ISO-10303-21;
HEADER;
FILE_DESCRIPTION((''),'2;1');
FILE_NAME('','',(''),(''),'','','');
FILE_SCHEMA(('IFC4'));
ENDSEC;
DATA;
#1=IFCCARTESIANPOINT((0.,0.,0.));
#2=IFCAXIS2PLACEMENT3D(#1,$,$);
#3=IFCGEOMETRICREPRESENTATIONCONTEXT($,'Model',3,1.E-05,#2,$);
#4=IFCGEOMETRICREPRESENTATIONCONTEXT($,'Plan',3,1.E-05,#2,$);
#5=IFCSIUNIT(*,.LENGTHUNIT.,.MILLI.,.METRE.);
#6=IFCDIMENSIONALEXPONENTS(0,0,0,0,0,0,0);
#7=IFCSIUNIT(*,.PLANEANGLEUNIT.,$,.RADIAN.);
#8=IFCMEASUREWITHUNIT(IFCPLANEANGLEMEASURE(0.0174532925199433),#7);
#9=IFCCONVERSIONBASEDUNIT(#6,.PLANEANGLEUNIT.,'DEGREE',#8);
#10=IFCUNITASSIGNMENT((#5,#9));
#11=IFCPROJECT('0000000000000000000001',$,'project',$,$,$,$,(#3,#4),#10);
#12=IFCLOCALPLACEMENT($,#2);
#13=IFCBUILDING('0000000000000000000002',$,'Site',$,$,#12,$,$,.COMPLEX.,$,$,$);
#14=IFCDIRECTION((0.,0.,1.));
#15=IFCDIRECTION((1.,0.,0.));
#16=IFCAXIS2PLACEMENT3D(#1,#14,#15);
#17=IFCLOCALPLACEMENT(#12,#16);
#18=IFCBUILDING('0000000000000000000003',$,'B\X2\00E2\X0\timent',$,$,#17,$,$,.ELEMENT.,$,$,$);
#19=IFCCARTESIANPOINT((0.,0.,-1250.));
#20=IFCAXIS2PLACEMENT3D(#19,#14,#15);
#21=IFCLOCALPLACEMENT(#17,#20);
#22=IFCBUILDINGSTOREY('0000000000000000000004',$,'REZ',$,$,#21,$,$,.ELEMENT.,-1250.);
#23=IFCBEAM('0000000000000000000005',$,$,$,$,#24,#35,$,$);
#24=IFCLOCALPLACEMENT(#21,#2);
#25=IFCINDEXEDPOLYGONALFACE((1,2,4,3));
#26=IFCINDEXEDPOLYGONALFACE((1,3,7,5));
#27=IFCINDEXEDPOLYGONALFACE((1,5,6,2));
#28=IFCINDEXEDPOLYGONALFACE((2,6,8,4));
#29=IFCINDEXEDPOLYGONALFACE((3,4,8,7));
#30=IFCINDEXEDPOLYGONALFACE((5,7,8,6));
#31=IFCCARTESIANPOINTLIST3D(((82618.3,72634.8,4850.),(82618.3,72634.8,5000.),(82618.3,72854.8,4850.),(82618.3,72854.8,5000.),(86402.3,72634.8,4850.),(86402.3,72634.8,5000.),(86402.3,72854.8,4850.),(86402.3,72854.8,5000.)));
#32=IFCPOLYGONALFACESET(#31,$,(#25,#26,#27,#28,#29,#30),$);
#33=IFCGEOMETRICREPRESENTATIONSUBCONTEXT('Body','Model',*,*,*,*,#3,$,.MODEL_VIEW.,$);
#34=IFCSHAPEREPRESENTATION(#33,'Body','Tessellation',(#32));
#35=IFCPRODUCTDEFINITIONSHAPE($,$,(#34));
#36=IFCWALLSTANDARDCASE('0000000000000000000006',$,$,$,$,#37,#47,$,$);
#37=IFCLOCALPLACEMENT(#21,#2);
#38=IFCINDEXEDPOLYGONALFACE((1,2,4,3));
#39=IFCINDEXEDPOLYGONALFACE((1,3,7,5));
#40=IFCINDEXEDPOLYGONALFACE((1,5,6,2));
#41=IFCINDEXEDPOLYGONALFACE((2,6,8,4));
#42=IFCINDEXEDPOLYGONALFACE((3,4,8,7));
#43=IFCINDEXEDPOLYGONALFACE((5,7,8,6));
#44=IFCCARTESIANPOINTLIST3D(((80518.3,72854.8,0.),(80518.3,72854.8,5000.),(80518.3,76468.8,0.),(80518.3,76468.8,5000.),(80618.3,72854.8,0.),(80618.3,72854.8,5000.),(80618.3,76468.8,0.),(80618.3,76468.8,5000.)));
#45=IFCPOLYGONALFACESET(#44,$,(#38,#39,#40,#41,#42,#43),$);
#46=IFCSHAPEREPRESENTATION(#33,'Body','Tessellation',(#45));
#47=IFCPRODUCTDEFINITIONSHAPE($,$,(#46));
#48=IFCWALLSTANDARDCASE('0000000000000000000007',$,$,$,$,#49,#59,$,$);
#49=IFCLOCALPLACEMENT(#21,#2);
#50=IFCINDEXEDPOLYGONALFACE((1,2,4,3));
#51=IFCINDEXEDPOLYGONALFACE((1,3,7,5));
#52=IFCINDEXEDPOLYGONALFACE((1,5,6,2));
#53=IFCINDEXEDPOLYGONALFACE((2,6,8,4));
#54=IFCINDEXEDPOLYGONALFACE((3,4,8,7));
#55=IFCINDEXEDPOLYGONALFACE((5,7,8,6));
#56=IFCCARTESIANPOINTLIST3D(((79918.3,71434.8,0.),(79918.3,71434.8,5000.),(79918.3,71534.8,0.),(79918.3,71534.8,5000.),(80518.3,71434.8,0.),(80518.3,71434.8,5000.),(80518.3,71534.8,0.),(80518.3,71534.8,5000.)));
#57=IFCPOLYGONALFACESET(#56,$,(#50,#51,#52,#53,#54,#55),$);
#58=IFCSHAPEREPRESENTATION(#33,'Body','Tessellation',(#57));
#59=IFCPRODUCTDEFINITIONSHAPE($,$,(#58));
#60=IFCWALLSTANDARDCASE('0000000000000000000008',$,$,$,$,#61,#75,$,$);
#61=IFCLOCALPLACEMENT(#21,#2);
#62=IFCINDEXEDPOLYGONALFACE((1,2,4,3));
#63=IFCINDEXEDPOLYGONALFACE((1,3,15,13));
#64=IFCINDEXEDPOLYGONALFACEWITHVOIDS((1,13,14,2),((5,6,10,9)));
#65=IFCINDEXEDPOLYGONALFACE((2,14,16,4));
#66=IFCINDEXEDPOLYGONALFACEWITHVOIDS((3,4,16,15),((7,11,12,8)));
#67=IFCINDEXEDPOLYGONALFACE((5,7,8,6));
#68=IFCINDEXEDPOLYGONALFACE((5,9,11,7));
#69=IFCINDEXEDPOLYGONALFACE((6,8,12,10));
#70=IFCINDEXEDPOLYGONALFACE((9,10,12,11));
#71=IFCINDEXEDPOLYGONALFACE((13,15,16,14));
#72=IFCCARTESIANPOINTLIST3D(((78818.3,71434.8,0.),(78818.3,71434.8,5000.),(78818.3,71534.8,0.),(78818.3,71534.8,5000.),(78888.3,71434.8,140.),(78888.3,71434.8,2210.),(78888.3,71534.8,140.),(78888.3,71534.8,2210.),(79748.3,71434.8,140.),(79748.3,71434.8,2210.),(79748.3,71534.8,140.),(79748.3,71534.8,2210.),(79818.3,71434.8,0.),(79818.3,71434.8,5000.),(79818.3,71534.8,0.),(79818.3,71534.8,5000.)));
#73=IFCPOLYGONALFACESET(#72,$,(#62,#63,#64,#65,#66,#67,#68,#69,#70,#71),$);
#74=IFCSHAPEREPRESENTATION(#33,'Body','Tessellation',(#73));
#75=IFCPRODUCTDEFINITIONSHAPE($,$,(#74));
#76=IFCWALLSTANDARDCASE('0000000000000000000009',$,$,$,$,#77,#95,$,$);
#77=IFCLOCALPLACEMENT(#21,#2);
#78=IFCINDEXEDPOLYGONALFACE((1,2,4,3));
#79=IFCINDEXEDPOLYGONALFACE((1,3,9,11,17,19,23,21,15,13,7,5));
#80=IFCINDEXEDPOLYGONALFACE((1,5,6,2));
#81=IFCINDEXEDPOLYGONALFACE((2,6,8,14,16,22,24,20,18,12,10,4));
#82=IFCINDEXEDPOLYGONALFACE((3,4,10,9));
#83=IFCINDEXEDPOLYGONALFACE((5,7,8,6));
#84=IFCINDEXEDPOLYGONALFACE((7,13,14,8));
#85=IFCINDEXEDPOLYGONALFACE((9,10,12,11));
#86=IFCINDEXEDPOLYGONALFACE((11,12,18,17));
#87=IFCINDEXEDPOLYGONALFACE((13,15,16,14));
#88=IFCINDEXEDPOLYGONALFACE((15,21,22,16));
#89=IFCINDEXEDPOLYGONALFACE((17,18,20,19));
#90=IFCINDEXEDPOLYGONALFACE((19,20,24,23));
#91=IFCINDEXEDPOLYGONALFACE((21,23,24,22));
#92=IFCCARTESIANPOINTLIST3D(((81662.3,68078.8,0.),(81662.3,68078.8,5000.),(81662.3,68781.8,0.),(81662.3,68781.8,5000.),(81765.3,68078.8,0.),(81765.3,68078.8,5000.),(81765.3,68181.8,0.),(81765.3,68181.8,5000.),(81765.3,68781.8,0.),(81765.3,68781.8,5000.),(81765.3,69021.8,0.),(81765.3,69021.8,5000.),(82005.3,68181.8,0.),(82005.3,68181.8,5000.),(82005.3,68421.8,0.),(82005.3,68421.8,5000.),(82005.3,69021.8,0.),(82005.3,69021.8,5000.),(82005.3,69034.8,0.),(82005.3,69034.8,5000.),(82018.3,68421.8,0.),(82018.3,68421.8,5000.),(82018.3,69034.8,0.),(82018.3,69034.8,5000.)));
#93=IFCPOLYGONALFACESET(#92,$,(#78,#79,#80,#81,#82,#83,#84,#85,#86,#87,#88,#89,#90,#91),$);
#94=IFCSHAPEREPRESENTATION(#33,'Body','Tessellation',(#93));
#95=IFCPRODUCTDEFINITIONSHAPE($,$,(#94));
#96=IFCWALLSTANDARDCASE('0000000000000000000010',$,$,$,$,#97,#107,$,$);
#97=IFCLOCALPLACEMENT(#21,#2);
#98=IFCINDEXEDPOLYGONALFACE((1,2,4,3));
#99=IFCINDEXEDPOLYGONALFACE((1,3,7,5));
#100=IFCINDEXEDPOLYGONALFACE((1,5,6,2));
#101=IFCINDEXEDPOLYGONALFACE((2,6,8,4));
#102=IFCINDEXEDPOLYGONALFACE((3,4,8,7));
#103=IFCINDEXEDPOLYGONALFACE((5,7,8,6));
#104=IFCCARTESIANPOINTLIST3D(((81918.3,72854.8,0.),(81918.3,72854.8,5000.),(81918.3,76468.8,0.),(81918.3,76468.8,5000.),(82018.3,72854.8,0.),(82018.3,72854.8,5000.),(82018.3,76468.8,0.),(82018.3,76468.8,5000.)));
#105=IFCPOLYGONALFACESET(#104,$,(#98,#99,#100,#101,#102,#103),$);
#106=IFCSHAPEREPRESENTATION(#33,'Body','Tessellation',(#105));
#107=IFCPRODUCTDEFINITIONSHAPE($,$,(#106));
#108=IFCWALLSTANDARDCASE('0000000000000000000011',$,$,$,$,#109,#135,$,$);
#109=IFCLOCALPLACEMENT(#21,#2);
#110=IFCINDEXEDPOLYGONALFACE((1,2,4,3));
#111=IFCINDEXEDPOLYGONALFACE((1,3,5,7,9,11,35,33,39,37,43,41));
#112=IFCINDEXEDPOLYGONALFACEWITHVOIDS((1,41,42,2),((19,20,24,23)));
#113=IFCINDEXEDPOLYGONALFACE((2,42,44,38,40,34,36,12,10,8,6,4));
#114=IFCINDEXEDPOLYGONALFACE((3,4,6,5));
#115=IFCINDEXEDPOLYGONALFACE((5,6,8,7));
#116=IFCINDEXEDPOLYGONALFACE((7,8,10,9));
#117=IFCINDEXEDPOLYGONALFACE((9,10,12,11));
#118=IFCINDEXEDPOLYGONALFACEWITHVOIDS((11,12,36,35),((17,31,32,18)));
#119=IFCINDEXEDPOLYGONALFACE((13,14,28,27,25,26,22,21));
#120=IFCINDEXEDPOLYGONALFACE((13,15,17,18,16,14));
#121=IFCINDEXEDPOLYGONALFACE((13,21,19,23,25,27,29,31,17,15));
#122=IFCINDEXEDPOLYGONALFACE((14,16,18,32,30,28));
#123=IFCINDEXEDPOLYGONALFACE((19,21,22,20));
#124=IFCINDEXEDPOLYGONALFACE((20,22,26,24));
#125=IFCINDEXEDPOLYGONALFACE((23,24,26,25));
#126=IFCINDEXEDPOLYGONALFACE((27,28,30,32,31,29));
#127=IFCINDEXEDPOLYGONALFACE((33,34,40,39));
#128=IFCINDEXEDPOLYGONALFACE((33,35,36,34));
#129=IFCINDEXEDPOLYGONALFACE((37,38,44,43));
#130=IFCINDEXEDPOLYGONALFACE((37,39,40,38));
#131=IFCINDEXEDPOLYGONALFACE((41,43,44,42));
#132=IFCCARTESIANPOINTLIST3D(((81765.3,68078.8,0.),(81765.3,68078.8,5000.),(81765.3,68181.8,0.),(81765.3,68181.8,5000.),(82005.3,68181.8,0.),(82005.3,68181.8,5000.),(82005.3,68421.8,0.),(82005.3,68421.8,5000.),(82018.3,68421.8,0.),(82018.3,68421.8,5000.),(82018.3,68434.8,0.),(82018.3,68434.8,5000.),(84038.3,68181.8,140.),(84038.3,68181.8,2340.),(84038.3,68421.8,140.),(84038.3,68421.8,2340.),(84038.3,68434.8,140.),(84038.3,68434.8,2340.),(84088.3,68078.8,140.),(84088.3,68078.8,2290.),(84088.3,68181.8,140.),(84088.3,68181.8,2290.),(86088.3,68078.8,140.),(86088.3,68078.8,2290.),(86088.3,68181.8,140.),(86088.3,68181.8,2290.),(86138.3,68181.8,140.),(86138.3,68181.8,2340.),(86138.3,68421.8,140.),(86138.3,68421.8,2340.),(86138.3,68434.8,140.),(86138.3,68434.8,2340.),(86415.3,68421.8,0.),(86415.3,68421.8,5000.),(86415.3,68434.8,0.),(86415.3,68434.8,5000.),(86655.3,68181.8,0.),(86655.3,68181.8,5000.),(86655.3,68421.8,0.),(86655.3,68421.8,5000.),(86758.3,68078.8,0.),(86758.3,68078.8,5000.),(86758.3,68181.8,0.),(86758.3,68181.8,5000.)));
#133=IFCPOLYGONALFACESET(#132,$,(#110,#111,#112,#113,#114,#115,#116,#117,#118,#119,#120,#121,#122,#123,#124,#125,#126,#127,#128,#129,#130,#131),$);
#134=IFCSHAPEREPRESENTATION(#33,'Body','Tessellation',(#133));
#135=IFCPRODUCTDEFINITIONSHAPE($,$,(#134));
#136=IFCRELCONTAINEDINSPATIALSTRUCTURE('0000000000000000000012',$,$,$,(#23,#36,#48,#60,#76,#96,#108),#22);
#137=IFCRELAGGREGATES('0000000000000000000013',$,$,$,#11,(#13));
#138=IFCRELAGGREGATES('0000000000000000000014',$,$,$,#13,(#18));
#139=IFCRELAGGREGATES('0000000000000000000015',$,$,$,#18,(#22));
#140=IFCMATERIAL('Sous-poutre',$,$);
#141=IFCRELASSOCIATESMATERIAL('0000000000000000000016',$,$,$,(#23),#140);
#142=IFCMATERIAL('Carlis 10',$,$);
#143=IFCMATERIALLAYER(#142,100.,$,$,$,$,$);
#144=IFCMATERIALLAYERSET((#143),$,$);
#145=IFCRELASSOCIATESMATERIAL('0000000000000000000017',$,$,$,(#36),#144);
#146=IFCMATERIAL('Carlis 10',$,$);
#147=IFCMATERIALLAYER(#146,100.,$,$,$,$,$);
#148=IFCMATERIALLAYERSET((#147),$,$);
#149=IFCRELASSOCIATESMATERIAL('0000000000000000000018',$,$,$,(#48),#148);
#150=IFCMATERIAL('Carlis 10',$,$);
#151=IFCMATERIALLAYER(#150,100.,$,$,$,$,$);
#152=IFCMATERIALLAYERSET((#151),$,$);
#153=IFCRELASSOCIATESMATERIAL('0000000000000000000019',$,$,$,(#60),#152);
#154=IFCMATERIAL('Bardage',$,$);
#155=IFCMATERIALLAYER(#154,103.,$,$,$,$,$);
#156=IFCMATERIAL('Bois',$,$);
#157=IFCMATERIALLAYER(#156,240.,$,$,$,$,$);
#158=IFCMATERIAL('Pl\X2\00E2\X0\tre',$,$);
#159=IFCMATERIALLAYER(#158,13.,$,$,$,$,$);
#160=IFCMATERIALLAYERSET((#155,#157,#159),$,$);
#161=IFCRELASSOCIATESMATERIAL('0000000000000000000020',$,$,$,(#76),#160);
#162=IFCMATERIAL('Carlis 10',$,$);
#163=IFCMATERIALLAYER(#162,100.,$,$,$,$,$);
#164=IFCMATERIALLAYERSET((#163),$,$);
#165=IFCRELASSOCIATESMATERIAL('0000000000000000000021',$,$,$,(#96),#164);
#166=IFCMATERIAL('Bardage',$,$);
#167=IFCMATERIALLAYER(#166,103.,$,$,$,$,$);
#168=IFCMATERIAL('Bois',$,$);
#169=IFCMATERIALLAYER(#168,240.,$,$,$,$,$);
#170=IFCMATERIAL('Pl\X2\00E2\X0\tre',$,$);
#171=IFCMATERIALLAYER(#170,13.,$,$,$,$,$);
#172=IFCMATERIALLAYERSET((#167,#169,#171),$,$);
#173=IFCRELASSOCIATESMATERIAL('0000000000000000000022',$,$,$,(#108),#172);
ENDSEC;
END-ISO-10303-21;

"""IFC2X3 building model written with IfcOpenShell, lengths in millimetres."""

from ifc_helpers import new_model, entity, si_unit, converted_unit, frame, frame_2d, origin, origin_with_axes, place, context, subcontext, project, spatial, polyline, rectangle, outline, extrude, material, layer, layer_set, layer_usage, element, save


model = new_model("IFC2X3")

# Units and contexts
model_context = context("Model", 3, precision=1e-05, world=origin())
plan_context = context("Plan", 3, precision=1e-05, world=origin())
body_context = subcontext(model_context, "Body", "Model", "MODEL_VIEW")
ifc_project = project(units=[si_unit("LENGTHUNIT", "METRE", prefix="MILLI"), converted_unit("PLANEANGLEUNIT", "DEGREE", entity("IfcPlaneAngleMeasure", 0.0174532925199433), si_unit("PLANEANGLEUNIT", "RADIAN"), dimensions=[0, 0, 0, 0, 0, 0, 0])], contexts=[model_context, plan_context])

# Buildings, storey
building_1_placement = place(None, origin())
building_1 = spatial("IfcBuilding", under=ifc_project, at=building_1_placement, Name="Site", CompositionType="COMPLEX")
building_2_placement = place(building_1_placement, origin_with_axes())
building_2 = spatial("IfcBuilding", under=building_1, at=building_2_placement, Name="Bâtiment", CompositionType="ELEMENT")
storey_placement = place(building_2_placement, frame((0.0, 0.0, -1250.0), z_axis=(0.0, 0.0, 1.0), x_axis=(1.0, 0.0, 0.0)))
storey = spatial("IfcBuildingStorey", under=building_2, at=storey_placement, Name="REZ", CompositionType="ELEMENT", Elevation=-1250.0)

# Beam
ifc_material_1 = material(Name="Sous-poutre")
beam_placement = place(storey_placement, frame((82618.3, 72634.8, 4850.0), z_axis=(0.0, 0.0, 1.0), x_axis=(1.0, 0.0, 0.0)))
element("IfcBeam", 1, at=beam_placement, inside=storey, material=ifc_material_1, context=body_context, shape_type="SweptSolid", body=[
    extrude(rectangle(XDim=150.0, YDim=220.0, at=frame_2d((75.0, -110.0), x_axis=(1.0, 0.0))), frame((0.0, 0.0, 0.0), z_axis=(1.0, 0.0, 0.0), x_axis=(0.0, 0.0, 1.0)), (0.0, 0.0, 1.0), 3784.0),
])

# Wall
ifc_material_2 = material(Name="Carlis 10")
ifc_layer_1 = layer(ifc_material_2, 100.0)
ifc_layer_set_1 = layer_set([ifc_layer_1])
ifc_layer_usage_1 = layer_usage(ifc_layer_set_1, "AXIS2", "POSITIVE", 0.0)
wall_1_placement = place(storey_placement, frame((80518.3, 76468.8, 0.0), z_axis=(0.0, 0.0, 1.0), x_axis=(0.0, -1.0, 0.0)))
element("IfcWallStandardCase", 2, at=wall_1_placement, inside=storey, material=ifc_layer_usage_1, context=body_context, shape_type="SweptSolid", body=[
    extrude(rectangle(XDim=3614.0, YDim=100.0, at=frame_2d((1807.0, 50.0), x_axis=(1.0, 0.0))), origin_with_axes(), (0.0, 0.0, 1.0), 5000.0),
])

# Wall
ifc_material_3 = material(Name="Carlis 10")
ifc_layer_2 = layer(ifc_material_3, 100.0)
ifc_layer_set_2 = layer_set([ifc_layer_2])
ifc_layer_usage_2 = layer_usage(ifc_layer_set_2, "AXIS2", "POSITIVE", 0.0)
wall_2_placement = place(storey_placement, frame((80518.3, 71534.8, 0.0), z_axis=(0.0, 0.0, 1.0), x_axis=(-1.0, 0.0, 0.0)))
element("IfcWallStandardCase", 3, at=wall_2_placement, inside=storey, material=ifc_layer_usage_2, context=body_context, shape_type="SweptSolid", body=[
    extrude(outline(polyline([(600.0, 0.0), (600.0, 100.0), (0.0, 100.0), (0.0, 0.0), (600.0, 0.0)])), frame((0.0, 0.0, 0.0), z_axis=(0.0, 0.0, 1.0), x_axis=(1.0, 0.0, 0.0)), (0.0, 0.0, 1.0), 5000.0),
])

# Wall, opening
ifc_material_4 = material(Name="Carlis 10")
ifc_layer_3 = layer(ifc_material_4, 100.0)
ifc_layer_set_3 = layer_set([ifc_layer_3])
ifc_layer_usage_3 = layer_usage(ifc_layer_set_3, "AXIS2", "POSITIVE", 0.0)
wall_3_placement = place(storey_placement, frame((80518.3, 71534.8, 0.0), z_axis=(0.0, 0.0, 1.0), x_axis=(-1.0, 0.0, 0.0)))
wall_3 = element("IfcWallStandardCase", 4, at=wall_3_placement, inside=storey, material=ifc_layer_usage_3, context=body_context, shape_type="SweptSolid", body=[
    extrude(outline(polyline([(1000.0, 100.0), (0.0, 100.0), (0.0, 0.0), (1000.0, 0.0), (1000.0, 100.0)])), frame((700.0, 0.0, 0.0), z_axis=(0.0, 0.0, 1.0), x_axis=(1.0, 0.0, 0.0)), (0.0, 0.0, 1.0), 5000.0),
])
opening_1_placement = place(wall_3_placement, frame((770.0, 0.0, 140.0), z_axis=(0.0, 1.0, 0.0), x_axis=(0.0, 0.0, 1.0)))
element("IfcOpeningElement", 5, at=opening_1_placement, cuts=wall_3, ObjectType="Opening", context=body_context, shape_type="SweptSolid", body=[
    extrude(rectangle(XDim=2070.0, YDim=860.0, at=frame_2d((1035.0, 430.0), x_axis=(1.0, 0.0))), origin_with_axes(), (0.0, 0.0, 1.0), 100.0),
])

# Walls
ifc_material_5 = material(Name="Bardage")
ifc_layer_4 = layer(ifc_material_5, 103.0)
ifc_material_6 = material(Name="Bois")
ifc_layer_5 = layer(ifc_material_6, 240.0)
ifc_material_7 = material(Name="Plâtre")
ifc_layer_6 = layer(ifc_material_7, 13.0)
ifc_layer_set_4 = layer_set([ifc_layer_4, ifc_layer_5, ifc_layer_6])
ifc_layer_usage_4 = layer_usage(ifc_layer_set_4, "AXIS2", "POSITIVE", 0.0)
wall_4_placement = place(storey_placement, frame((81662.3, 68781.8, 0.0), z_axis=(0.0, 0.0, 1.0), x_axis=(0.0, -1.0, 0.0)))
element("IfcWallStandardCase", 6, at=wall_4_placement, inside=storey, material=ifc_layer_usage_4, context=body_context, shape_type="SweptSolid", body=[
    extrude(outline(polyline([(0.0, 0.0), (703.0, 0.0), (703.0, 103.0), (600.0, 103.0), (600.0, 343.0), (360.0, 343.0), (360.0, 356.0), (-253.0, 356.0), (-253.0, 343.0), (-240.0, 343.0), (-240.0, 103.0), (0.0, 103.0), (0.0, 0.0)])), origin_with_axes(), (0.0, 0.0, 1.0), 5000.0),
])
ifc_material_8 = material(Name="Carlis 10")
ifc_layer_7 = layer(ifc_material_8, 100.0)
ifc_layer_set_5 = layer_set([ifc_layer_7])
ifc_layer_usage_5 = layer_usage(ifc_layer_set_5, "AXIS2", "POSITIVE", 0.0)
wall_5_placement = place(storey_placement, frame((81918.3, 76468.8, 0.0), z_axis=(0.0, 0.0, 1.0), x_axis=(0.0, -1.0, 0.0)))
element("IfcWallStandardCase", 7, at=wall_5_placement, inside=storey, material=ifc_layer_usage_5, context=body_context, shape_type="SweptSolid", body=[
    extrude(rectangle(XDim=3614.0, YDim=100.0, at=frame_2d((1807.0, 50.0), x_axis=(1.0, 0.0))), origin_with_axes(), (0.0, 0.0, 1.0), 5000.0),
])

# Wall, opening
ifc_material_9 = material(Name="Bardage")
ifc_layer_8 = layer(ifc_material_9, 103.0)
ifc_material_10 = material(Name="Bois")
ifc_layer_9 = layer(ifc_material_10, 240.0)
ifc_material_11 = material(Name="Plâtre")
ifc_layer_10 = layer(ifc_material_11, 13.0)
ifc_layer_set_6 = layer_set([ifc_layer_8, ifc_layer_9, ifc_layer_10])
ifc_layer_usage_6 = layer_usage(ifc_layer_set_6, "AXIS2", "POSITIVE", 0.0)
wall_6_placement = place(storey_placement, frame((81765.3, 68078.8, 0.0), z_axis=(0.0, 0.0, 1.0), x_axis=(1.0, 0.0, 0.0)))
wall_6 = element("IfcWallStandardCase", 8, at=wall_6_placement, inside=storey, material=ifc_layer_usage_6, context=body_context, shape_type="SweptSolid", body=[
    extrude(outline(polyline([(0.0, 0.0), (4993.0, 0.0), (4993.0, 103.0), (4890.0, 103.0), (4890.0, 343.0), (4650.0, 343.0), (4650.0, 356.0), (253.0, 356.0), (253.0, 343.0), (240.0, 343.0), (240.0, 103.0), (0.0, 103.0), (0.0, 0.0)])), origin_with_axes(), (0.0, 0.0, 1.0), 5000.0),
])
opening_2_placement = place(wall_6_placement, frame((2323.0, 0.0, 140.0), z_axis=(0.0, 1.0, 0.0), x_axis=(0.0, 0.0, 1.0)))
element("IfcOpeningElement", 9, at=opening_2_placement, cuts=wall_6, ObjectType="Opening", context=body_context, shape_type="SweptSolid", body=[
    extrude(rectangle(XDim=2150.0, YDim=2000.0, at=frame_2d((1075.0, 1000.0), x_axis=(1.0, 0.0))), origin_with_axes(), (0.0, 0.0, 1.0), 103.0),
    extrude(rectangle(XDim=2200.0, YDim=2100.0, at=frame_2d((1100.0, 1050.0), x_axis=(1.0, 0.0))), frame((0.0, -50.0, 103.0), z_axis=(0.0, 0.0, 1.0), x_axis=(1.0, 0.0, 0.0)), (0.0, 0.0, 1.0), 240.0),
    extrude(rectangle(XDim=2200.0, YDim=2100.0, at=frame_2d((1100.0, 1050.0), x_axis=(1.0, 0.0))), frame((0.0, -50.0, 343.0), z_axis=(0.0, 0.0, 1.0), x_axis=(1.0, 0.0, 0.0)), (0.0, 0.0, 1.0), 13.0),
])

save(model, "model.ifc")
